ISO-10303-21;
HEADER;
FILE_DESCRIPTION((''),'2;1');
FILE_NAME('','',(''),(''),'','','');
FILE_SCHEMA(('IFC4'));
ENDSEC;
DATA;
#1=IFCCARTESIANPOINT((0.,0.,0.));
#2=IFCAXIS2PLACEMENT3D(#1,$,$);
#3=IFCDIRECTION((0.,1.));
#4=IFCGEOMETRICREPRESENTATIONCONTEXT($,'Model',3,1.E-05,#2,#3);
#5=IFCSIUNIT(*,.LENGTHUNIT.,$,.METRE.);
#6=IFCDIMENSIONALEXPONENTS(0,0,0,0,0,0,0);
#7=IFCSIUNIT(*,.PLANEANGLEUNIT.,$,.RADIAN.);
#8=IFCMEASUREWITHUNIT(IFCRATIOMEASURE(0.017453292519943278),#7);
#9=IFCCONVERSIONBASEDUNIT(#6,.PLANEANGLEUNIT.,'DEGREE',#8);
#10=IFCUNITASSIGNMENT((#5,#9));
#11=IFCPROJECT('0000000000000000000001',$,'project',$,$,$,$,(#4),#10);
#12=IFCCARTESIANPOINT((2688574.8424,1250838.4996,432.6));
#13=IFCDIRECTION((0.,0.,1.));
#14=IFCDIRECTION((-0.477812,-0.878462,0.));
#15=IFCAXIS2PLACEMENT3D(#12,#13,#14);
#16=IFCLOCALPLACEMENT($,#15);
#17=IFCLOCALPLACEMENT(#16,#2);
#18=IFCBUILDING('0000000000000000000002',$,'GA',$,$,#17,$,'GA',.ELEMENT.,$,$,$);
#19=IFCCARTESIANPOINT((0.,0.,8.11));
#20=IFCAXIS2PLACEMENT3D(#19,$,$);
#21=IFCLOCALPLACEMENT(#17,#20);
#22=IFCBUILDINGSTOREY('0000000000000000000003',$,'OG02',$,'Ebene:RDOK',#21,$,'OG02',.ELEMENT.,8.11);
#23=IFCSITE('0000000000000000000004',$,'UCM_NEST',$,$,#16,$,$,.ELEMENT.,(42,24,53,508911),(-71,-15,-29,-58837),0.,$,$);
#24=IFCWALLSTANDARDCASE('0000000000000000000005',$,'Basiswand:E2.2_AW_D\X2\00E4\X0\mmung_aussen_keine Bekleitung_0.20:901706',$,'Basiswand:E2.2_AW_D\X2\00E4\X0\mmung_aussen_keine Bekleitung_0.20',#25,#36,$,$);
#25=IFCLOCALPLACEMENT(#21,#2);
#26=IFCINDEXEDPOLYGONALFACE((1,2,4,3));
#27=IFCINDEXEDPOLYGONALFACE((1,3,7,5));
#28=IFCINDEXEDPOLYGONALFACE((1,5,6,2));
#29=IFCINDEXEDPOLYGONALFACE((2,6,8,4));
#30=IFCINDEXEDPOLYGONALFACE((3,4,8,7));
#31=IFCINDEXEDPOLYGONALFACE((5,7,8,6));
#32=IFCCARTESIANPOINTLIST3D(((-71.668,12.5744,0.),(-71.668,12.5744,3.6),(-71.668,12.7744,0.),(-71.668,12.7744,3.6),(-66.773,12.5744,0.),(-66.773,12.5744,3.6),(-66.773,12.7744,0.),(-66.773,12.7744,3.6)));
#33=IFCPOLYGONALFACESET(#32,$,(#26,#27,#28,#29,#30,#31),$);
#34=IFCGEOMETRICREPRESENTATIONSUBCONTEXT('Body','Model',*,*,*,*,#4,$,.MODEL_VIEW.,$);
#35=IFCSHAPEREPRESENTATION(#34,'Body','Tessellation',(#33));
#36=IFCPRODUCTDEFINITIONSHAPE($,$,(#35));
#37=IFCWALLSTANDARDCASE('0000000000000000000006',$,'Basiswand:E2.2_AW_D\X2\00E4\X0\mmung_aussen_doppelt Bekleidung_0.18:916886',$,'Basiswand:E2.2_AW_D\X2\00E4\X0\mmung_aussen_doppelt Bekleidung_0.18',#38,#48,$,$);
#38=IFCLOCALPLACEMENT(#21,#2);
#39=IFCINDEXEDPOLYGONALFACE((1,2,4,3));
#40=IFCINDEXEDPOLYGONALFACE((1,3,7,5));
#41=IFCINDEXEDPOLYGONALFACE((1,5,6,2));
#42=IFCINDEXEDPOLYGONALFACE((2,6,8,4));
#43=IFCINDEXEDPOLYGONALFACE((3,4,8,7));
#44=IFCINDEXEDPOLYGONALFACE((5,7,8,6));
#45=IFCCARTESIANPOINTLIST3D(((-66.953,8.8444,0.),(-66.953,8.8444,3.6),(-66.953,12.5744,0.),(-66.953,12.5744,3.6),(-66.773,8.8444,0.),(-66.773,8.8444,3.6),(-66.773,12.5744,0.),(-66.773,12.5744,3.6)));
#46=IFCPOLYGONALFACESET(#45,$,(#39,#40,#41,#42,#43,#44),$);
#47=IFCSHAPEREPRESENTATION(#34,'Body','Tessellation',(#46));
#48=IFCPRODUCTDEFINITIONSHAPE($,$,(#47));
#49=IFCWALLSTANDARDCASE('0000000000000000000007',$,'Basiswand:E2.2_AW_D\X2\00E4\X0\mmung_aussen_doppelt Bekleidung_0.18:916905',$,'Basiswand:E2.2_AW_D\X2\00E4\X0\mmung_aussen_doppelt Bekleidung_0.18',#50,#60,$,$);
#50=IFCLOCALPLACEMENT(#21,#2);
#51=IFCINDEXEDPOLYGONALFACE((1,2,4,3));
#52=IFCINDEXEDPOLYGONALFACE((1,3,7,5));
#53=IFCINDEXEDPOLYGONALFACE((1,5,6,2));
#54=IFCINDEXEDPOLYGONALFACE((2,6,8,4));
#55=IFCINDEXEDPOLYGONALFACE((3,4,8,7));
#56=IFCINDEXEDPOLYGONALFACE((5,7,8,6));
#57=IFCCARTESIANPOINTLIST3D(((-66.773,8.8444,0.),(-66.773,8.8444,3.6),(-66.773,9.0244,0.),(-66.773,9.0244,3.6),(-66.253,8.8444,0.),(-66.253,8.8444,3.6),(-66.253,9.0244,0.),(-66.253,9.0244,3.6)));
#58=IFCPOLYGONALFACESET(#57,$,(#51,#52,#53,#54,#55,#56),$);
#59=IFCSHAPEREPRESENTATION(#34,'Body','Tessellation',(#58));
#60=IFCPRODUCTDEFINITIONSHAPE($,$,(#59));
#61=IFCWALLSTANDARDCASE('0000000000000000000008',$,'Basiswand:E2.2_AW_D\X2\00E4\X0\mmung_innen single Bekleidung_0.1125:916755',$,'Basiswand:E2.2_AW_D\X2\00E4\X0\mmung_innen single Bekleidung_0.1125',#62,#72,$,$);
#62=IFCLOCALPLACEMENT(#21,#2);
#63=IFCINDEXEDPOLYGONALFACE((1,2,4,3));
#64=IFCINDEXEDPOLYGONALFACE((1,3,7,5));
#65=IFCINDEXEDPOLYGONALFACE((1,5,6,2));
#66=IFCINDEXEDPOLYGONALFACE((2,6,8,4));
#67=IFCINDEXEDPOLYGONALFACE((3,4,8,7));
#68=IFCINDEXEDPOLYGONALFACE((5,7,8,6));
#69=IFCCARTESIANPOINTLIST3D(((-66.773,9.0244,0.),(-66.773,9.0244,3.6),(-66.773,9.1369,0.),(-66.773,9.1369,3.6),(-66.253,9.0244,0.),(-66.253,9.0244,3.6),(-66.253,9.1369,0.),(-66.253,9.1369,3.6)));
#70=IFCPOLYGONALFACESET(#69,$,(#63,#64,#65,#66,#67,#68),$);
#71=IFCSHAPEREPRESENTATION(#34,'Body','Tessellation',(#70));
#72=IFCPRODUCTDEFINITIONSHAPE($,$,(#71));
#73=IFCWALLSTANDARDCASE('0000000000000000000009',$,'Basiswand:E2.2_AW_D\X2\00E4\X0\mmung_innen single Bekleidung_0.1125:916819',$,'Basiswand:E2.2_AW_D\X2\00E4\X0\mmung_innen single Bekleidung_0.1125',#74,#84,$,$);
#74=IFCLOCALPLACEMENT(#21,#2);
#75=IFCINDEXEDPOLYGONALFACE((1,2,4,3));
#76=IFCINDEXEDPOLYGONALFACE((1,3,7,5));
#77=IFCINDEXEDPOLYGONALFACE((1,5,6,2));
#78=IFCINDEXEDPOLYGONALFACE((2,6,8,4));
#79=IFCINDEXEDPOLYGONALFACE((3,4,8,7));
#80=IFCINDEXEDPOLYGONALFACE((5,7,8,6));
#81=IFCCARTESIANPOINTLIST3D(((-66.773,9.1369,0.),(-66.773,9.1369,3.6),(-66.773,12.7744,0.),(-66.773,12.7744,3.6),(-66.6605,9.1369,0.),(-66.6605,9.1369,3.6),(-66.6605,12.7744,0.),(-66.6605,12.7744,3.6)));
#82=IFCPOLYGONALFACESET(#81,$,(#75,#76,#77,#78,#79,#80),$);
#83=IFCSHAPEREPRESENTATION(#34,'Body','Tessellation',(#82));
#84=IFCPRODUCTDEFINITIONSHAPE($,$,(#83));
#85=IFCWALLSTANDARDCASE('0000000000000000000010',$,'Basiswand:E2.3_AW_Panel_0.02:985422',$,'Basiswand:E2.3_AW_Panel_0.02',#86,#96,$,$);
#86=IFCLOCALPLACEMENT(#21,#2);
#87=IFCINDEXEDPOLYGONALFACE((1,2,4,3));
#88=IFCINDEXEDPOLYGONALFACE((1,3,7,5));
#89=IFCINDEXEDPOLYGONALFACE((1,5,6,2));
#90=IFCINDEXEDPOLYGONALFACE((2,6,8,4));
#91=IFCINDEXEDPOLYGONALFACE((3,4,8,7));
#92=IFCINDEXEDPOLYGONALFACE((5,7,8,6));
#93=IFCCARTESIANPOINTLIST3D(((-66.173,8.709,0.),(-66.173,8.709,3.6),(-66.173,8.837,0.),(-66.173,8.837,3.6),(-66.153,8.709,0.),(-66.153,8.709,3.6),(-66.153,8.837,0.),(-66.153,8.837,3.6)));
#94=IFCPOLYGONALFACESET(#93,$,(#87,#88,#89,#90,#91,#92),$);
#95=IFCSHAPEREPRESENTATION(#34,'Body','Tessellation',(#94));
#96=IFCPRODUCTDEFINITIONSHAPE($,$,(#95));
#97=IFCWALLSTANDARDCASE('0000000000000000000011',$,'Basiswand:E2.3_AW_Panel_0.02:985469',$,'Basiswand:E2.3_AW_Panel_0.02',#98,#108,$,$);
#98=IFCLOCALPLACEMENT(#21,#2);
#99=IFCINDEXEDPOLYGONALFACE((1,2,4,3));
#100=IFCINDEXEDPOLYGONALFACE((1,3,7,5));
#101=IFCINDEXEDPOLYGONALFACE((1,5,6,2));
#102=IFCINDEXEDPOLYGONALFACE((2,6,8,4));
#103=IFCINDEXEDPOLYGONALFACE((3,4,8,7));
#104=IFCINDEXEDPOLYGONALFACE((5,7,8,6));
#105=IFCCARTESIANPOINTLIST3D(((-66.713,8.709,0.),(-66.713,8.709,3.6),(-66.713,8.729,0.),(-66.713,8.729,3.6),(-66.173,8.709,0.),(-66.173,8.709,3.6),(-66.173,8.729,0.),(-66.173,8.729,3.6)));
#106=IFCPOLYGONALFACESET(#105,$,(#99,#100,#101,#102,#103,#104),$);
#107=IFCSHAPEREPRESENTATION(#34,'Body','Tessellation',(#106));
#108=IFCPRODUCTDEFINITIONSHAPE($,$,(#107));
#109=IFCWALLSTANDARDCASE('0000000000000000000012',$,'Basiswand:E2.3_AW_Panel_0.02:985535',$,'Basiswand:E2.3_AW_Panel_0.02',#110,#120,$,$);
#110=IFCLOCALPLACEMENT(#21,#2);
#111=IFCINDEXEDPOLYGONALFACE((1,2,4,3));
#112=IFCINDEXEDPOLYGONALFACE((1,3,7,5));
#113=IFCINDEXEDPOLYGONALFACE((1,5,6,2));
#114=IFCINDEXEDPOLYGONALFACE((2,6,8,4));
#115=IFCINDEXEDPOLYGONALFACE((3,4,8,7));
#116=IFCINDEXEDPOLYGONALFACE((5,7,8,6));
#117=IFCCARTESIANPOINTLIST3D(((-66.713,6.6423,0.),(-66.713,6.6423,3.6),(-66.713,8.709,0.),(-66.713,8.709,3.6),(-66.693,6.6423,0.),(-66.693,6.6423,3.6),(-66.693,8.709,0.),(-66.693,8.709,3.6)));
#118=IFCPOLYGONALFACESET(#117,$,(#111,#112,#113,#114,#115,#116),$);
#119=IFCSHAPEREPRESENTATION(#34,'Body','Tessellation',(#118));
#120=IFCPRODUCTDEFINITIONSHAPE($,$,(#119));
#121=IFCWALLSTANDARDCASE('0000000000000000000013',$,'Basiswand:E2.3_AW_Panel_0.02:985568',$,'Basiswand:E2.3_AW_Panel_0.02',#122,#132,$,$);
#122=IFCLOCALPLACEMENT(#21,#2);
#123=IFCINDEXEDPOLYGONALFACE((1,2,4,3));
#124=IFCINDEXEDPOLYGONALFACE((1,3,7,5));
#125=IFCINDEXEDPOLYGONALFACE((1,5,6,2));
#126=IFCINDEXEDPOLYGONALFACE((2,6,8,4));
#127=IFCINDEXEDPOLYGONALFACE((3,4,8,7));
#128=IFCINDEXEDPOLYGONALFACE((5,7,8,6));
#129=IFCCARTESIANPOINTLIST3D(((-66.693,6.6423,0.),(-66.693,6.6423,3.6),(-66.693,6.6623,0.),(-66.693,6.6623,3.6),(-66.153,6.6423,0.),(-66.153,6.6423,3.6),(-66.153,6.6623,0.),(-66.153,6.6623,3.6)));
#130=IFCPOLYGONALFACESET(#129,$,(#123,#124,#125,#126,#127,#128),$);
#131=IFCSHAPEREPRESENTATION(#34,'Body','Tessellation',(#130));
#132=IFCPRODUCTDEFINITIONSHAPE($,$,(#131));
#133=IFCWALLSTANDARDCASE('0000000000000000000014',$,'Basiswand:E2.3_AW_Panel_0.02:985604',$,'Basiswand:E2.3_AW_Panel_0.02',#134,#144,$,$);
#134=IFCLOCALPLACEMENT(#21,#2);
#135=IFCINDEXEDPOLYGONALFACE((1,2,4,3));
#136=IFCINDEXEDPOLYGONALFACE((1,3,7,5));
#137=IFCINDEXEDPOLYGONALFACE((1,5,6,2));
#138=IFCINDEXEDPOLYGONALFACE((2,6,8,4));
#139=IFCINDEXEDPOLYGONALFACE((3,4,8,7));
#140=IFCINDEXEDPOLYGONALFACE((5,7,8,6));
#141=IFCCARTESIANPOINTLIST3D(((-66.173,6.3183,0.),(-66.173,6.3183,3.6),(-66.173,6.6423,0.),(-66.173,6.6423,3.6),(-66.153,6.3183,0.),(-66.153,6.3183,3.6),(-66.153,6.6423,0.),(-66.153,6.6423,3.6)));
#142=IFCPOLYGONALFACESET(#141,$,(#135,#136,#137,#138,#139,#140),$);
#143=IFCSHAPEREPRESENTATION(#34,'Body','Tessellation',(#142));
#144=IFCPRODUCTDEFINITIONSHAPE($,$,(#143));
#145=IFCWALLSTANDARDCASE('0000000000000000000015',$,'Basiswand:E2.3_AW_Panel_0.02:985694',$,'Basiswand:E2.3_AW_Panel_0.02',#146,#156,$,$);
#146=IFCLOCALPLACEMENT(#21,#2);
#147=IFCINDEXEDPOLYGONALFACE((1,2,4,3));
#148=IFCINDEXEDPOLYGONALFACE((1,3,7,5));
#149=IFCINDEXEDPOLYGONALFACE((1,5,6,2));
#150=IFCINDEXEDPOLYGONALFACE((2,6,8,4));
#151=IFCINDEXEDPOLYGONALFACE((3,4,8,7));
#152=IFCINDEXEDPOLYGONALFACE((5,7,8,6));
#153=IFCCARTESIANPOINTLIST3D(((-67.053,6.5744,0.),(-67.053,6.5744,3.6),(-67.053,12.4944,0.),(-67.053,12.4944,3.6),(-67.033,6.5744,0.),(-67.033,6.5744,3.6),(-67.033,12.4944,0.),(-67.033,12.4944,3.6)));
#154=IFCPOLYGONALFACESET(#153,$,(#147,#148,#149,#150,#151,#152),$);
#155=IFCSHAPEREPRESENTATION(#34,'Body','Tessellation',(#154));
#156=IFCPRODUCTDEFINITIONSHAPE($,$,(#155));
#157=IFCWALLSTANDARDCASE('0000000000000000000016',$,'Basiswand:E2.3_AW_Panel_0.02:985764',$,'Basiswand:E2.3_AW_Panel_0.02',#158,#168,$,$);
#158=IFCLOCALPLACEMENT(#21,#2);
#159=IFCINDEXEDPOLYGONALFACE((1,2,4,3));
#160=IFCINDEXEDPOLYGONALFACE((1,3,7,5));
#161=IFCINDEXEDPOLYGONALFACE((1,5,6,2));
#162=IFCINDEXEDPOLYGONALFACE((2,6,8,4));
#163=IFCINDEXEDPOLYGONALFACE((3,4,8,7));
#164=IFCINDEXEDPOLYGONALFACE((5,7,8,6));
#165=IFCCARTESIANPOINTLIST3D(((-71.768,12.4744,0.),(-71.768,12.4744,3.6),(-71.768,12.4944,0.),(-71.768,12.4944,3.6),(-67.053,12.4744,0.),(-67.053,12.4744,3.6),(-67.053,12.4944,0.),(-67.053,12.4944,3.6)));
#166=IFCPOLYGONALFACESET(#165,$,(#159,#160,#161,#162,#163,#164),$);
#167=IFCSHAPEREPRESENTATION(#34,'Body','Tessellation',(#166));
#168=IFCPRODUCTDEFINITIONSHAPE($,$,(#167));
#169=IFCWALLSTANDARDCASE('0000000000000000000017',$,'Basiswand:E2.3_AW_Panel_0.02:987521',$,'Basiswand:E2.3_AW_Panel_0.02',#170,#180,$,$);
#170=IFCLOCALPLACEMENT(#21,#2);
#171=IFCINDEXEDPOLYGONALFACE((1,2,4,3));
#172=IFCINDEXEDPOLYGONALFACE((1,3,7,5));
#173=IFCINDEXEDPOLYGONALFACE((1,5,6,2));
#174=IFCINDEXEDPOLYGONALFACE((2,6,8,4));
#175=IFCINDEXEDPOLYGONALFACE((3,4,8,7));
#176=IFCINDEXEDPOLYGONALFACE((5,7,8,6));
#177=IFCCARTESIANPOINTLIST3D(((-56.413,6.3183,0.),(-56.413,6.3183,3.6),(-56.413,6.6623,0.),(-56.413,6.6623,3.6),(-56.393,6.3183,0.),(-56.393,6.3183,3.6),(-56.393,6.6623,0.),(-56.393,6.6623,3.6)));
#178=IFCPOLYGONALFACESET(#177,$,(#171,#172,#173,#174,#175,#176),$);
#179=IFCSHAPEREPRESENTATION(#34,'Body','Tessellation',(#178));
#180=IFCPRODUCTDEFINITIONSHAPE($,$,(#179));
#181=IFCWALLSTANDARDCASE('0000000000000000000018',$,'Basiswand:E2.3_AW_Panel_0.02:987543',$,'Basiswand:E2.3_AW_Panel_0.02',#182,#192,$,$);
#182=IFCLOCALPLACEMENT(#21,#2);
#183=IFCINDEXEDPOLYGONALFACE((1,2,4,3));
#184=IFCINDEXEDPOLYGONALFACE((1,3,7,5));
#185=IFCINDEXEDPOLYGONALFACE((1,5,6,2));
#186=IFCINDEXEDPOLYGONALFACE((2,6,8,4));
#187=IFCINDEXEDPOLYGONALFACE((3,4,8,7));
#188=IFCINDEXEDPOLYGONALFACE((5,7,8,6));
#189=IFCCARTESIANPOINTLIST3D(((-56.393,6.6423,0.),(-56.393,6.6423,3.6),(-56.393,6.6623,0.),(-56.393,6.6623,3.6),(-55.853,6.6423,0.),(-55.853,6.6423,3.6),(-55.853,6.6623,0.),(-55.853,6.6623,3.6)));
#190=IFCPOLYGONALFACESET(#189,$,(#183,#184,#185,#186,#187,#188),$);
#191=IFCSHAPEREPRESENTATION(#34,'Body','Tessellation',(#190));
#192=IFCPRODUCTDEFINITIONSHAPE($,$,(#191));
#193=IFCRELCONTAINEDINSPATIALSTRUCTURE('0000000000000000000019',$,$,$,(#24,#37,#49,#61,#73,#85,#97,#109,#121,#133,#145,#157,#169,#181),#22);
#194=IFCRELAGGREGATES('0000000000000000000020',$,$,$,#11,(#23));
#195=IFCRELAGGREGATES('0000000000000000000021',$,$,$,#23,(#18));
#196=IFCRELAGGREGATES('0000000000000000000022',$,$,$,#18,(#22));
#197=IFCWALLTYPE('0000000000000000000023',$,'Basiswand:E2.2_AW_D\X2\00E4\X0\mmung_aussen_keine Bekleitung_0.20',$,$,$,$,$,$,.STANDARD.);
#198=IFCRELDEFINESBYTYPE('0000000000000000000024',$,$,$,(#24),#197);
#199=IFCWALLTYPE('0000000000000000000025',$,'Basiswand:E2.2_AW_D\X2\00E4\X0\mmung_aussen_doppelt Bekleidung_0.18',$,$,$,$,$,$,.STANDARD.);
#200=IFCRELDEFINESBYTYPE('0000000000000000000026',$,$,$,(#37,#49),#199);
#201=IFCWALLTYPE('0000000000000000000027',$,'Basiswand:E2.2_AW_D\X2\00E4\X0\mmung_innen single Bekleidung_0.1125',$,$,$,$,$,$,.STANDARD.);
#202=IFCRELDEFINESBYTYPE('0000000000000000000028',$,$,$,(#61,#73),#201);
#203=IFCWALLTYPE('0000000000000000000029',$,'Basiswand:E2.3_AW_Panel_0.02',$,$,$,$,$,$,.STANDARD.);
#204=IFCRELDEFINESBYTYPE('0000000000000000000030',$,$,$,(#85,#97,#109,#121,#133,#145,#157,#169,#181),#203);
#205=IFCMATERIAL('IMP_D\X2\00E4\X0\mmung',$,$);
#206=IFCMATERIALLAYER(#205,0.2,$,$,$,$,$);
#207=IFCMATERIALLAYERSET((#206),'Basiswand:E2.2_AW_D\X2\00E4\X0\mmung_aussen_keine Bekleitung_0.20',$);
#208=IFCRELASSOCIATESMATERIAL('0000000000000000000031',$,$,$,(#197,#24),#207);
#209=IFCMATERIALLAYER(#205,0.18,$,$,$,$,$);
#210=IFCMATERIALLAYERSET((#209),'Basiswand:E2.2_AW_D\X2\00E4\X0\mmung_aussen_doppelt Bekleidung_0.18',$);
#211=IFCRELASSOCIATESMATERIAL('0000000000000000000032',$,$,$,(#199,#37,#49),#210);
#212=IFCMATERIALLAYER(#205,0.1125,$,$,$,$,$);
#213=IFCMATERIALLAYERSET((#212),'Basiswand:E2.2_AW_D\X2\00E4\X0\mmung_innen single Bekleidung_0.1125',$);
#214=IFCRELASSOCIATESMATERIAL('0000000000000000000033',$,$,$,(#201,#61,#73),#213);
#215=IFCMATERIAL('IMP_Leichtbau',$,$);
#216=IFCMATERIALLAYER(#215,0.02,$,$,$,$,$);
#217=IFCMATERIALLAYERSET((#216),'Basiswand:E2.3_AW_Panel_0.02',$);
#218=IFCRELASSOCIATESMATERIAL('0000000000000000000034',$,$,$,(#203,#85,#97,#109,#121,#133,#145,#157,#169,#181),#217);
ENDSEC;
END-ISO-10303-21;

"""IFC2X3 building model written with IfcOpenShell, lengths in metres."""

from ifc_helpers import new_model, entity, si_unit, converted_unit, direction, frame, frame_2d, origin, place, context, subcontext, project, spatial, rectangle, extrude, material, layer, layer_set, layer_usage, type_object, element, save


model = new_model("IFC2X3")

# Units and contexts
model_context = context("Model", 3, precision=1e-05, world=origin(), true_north=direction((0.0, 1.0)))
body_context = subcontext(model_context, "Body", "Model", "MODEL_VIEW")
ifc_project = project(units=[si_unit("LENGTHUNIT", "METRE"), converted_unit("PLANEANGLEUNIT", "DEGREE", entity("IfcRatioMeasure", 0.017453292519943278), si_unit("PLANEANGLEUNIT", "RADIAN"), dimensions=[0, 0, 0, 0, 0, 0, 0])], contexts=[model_context])

# Site, building, storey
site_placement = place(None, frame((2688574.8424, 1250838.4996, 432.6), z_axis=(0.0, 0.0, 1.0), x_axis=(-0.477812, -0.878462, 0.0)))
site = spatial("IfcSite", under=ifc_project, at=site_placement, Name="UCM_NEST", CompositionType="ELEMENT", RefLatitude=(42, 24, 53, 508911), RefLongitude=(-71, -15, -29, -58837), RefElevation=0.0)
building_placement = place(site_placement, origin())
building = spatial("IfcBuilding", under=site, at=building_placement, Name="GA", LongName="GA", CompositionType="ELEMENT")
storey_placement = place(building_placement, frame((0.0, 0.0, 8.11)))
storey = spatial("IfcBuildingStorey", under=building, at=storey_placement, Name="OG02", ObjectType="Ebene:RDOK", LongName="OG02", CompositionType="ELEMENT", Elevation=8.11)

# Walls
ifc_material_1 = material(Name="IMP_Dämmung")
ifc_layer_1 = layer(ifc_material_1, 0.2)
ifc_layer_set_1 = layer_set([ifc_layer_1], Name="Basiswand:E2.2_AW_Dämmung_aussen_keine Bekleitung_0.20")
ifc_layer_usage_1 = layer_usage(ifc_layer_set_1, "AXIS2", "NEGATIVE", 0.1)
wall_type_1 = type_object("IfcWallType", Name="Basiswand:E2.2_AW_Dämmung_aussen_keine Bekleitung_0.20", PredefinedType="STANDARD", material=ifc_layer_set_1)
wall_1_placement = place(storey_placement, frame((-66.773, 12.6744, 0.0), z_axis=(0.0, 0.0, 1.0), x_axis=(-1.0, 0.0, 0.0)))
element("IfcWallStandardCase", 1, at=wall_1_placement, inside=storey, type_object=wall_type_1, material=ifc_layer_usage_1, Name="Basiswand:E2.2_AW_Dämmung_aussen_keine Bekleitung_0.20:901706", ObjectType="Basiswand:E2.2_AW_Dämmung_aussen_keine Bekleitung_0.20", context=body_context, shape_type="SweptSolid", body=[
    extrude(rectangle(XDim=4.895, YDim=0.2, at=frame_2d((2.4475, 0.0), x_axis=(-1.0, 0.0))), origin(), (0.0, 0.0, 1.0), 3.6),
])
ifc_layer_2 = layer(ifc_material_1, 0.18)
ifc_layer_set_2 = layer_set([ifc_layer_2], Name="Basiswand:E2.2_AW_Dämmung_aussen_doppelt Bekleidung_0.18")
ifc_layer_usage_2 = layer_usage(ifc_layer_set_2, "AXIS2", "NEGATIVE", 0.09)
wall_type_2 = type_object("IfcWallType", Name="Basiswand:E2.2_AW_Dämmung_aussen_doppelt Bekleidung_0.18", PredefinedType="STANDARD", material=ifc_layer_set_2)
wall_2_placement = place(storey_placement, frame((-66.863, 12.5744, 0.0), z_axis=(0.0, 0.0, 1.0), x_axis=(0.0, -1.0, 0.0)))
element("IfcWallStandardCase", 2, at=wall_2_placement, inside=storey, type_object=wall_type_2, material=ifc_layer_usage_2, Name="Basiswand:E2.2_AW_Dämmung_aussen_doppelt Bekleidung_0.18:916886", ObjectType="Basiswand:E2.2_AW_Dämmung_aussen_doppelt Bekleidung_0.18", context=body_context, shape_type="SweptSolid", body=[
    extrude(rectangle(XDim=3.73, YDim=0.18, at=frame_2d((1.865, 0.0), x_axis=(-1.0, 0.0))), origin(), (0.0, 0.0, 1.0), 3.6),
])
wall_3_placement = place(storey_placement, frame((-66.773, 8.9344, 0.0)))
element("IfcWallStandardCase", 3, at=wall_3_placement, inside=storey, type_object=wall_type_2, material=ifc_layer_usage_2, Name="Basiswand:E2.2_AW_Dämmung_aussen_doppelt Bekleidung_0.18:916905", ObjectType="Basiswand:E2.2_AW_Dämmung_aussen_doppelt Bekleidung_0.18", context=body_context, shape_type="SweptSolid", body=[
    extrude(rectangle(XDim=0.52, YDim=0.18, at=frame_2d((0.26, 0.0), x_axis=(-1.0, 0.0))), origin(), (0.0, 0.0, 1.0), 3.6),
])
ifc_layer_3 = layer(ifc_material_1, 0.1125)
ifc_layer_set_3 = layer_set([ifc_layer_3], Name="Basiswand:E2.2_AW_Dämmung_innen single Bekleidung_0.1125")
ifc_layer_usage_3 = layer_usage(ifc_layer_set_3, "AXIS2", "NEGATIVE", 0.0562)
wall_type_3 = type_object("IfcWallType", Name="Basiswand:E2.2_AW_Dämmung_innen single Bekleidung_0.1125", PredefinedType="STANDARD", material=ifc_layer_set_3)
wall_4_placement = place(storey_placement, frame((-66.253, 9.0807, 0.0), z_axis=(0.0, 0.0, 1.0), x_axis=(-1.0, 0.0, 0.0)))
element("IfcWallStandardCase", 4, at=wall_4_placement, inside=storey, type_object=wall_type_3, material=ifc_layer_usage_3, Name="Basiswand:E2.2_AW_Dämmung_innen single Bekleidung_0.1125:916755", ObjectType="Basiswand:E2.2_AW_Dämmung_innen single Bekleidung_0.1125", context=body_context, shape_type="SweptSolid", body=[
    extrude(rectangle(XDim=0.52, YDim=0.1125, at=frame_2d((0.26, 0.0), x_axis=(-1.0, 0.0))), origin(), (0.0, 0.0, 1.0), 3.6),
])
wall_5_placement = place(storey_placement, frame((-66.7168, 9.1369, 0.0), z_axis=(0.0, 0.0, 1.0), x_axis=(0.0, 1.0, 0.0)))
element("IfcWallStandardCase", 5, at=wall_5_placement, inside=storey, type_object=wall_type_3, material=ifc_layer_usage_3, Name="Basiswand:E2.2_AW_Dämmung_innen single Bekleidung_0.1125:916819", ObjectType="Basiswand:E2.2_AW_Dämmung_innen single Bekleidung_0.1125", context=body_context, shape_type="SweptSolid", body=[
    extrude(rectangle(XDim=3.6375, YDim=0.1125, at=frame_2d((1.8187, 0.0), x_axis=(-1.0, 0.0))), origin(), (0.0, 0.0, 1.0), 3.6),
])
ifc_material_2 = material(Name="IMP_Leichtbau")
ifc_layer_4 = layer(ifc_material_2, 0.02)
ifc_layer_set_4 = layer_set([ifc_layer_4], Name="Basiswand:E2.3_AW_Panel_0.02")
ifc_layer_usage_4 = layer_usage(ifc_layer_set_4, "AXIS2", "NEGATIVE", 0.01)
wall_type_4 = type_object("IfcWallType", Name="Basiswand:E2.3_AW_Panel_0.02", PredefinedType="STANDARD", material=ifc_layer_set_4)
wall_6_placement = place(storey_placement, frame((-66.163, 8.837, 0.0), z_axis=(0.0, 0.0, 1.0), x_axis=(0.0, -1.0, 0.0)))
element("IfcWallStandardCase", 6, at=wall_6_placement, inside=storey, type_object=wall_type_4, material=ifc_layer_usage_4, Name="Basiswand:E2.3_AW_Panel_0.02:985422", ObjectType="Basiswand:E2.3_AW_Panel_0.02", context=body_context, shape_type="SweptSolid", body=[
    extrude(rectangle(XDim=0.128, YDim=0.02, at=frame_2d((0.064, 0.0), x_axis=(-1.0, 0.0))), origin(), (0.0, 0.0, 1.0), 3.6),
])
wall_7_placement = place(storey_placement, frame((-66.173, 8.719, 0.0), z_axis=(0.0, 0.0, 1.0), x_axis=(-1.0, 0.0, 0.0)))
element("IfcWallStandardCase", 7, at=wall_7_placement, inside=storey, type_object=wall_type_4, material=ifc_layer_usage_4, Name="Basiswand:E2.3_AW_Panel_0.02:985469", ObjectType="Basiswand:E2.3_AW_Panel_0.02", context=body_context, shape_type="SweptSolid", body=[
    extrude(rectangle(XDim=0.54, YDim=0.02, at=frame_2d((0.27, 0.0), x_axis=(-1.0, 0.0))), origin(), (0.0, 0.0, 1.0), 3.6),
])
wall_8_placement = place(storey_placement, frame((-66.703, 8.709, 0.0), z_axis=(0.0, 0.0, 1.0), x_axis=(0.0, -1.0, 0.0)))
element("IfcWallStandardCase", 8, at=wall_8_placement, inside=storey, type_object=wall_type_4, material=ifc_layer_usage_4, Name="Basiswand:E2.3_AW_Panel_0.02:985535", ObjectType="Basiswand:E2.3_AW_Panel_0.02", context=body_context, shape_type="SweptSolid", body=[
    extrude(rectangle(XDim=2.0667, YDim=0.02, at=frame_2d((1.0333, 0.0), x_axis=(-1.0, 0.0))), origin(), (0.0, 0.0, 1.0), 3.6),
])
wall_9_placement = place(storey_placement, frame((-66.693, 6.6523, 0.0)))
element("IfcWallStandardCase", 9, at=wall_9_placement, inside=storey, type_object=wall_type_4, material=ifc_layer_usage_4, Name="Basiswand:E2.3_AW_Panel_0.02:985568", ObjectType="Basiswand:E2.3_AW_Panel_0.02", context=body_context, shape_type="SweptSolid", body=[
    extrude(rectangle(XDim=0.54, YDim=0.02, at=frame_2d((0.27, 0.0), x_axis=(-1.0, 0.0))), origin(), (0.0, 0.0, 1.0), 3.6),
])
wall_10_placement = place(storey_placement, frame((-66.163, 6.6423, 0.0), z_axis=(0.0, 0.0, 1.0), x_axis=(0.0, -1.0, 0.0)))
element("IfcWallStandardCase", 10, at=wall_10_placement, inside=storey, type_object=wall_type_4, material=ifc_layer_usage_4, Name="Basiswand:E2.3_AW_Panel_0.02:985604", ObjectType="Basiswand:E2.3_AW_Panel_0.02", context=body_context, shape_type="SweptSolid", body=[
    extrude(rectangle(XDim=0.324, YDim=0.02, at=frame_2d((0.162, 0.0), x_axis=(-1.0, 0.0))), origin(), (0.0, 0.0, 1.0), 3.6),
])
wall_11_placement = place(storey_placement, frame((-67.043, 6.5744, 0.0), z_axis=(0.0, 0.0, 1.0), x_axis=(0.0, 1.0, 0.0)))
element("IfcWallStandardCase", 11, at=wall_11_placement, inside=storey, type_object=wall_type_4, material=ifc_layer_usage_4, Name="Basiswand:E2.3_AW_Panel_0.02:985694", ObjectType="Basiswand:E2.3_AW_Panel_0.02", context=body_context, shape_type="SweptSolid", body=[
    extrude(rectangle(XDim=5.92, YDim=0.02, at=frame_2d((2.96, 0.0), x_axis=(-1.0, 0.0))), origin(), (0.0, 0.0, 1.0), 3.6),
])
wall_12_placement = place(storey_placement, frame((-67.053, 12.4844, 0.0), z_axis=(0.0, 0.0, 1.0), x_axis=(-1.0, 0.0, 0.0)))
element("IfcWallStandardCase", 12, at=wall_12_placement, inside=storey, type_object=wall_type_4, material=ifc_layer_usage_4, Name="Basiswand:E2.3_AW_Panel_0.02:985764", ObjectType="Basiswand:E2.3_AW_Panel_0.02", context=body_context, shape_type="SweptSolid", body=[
    extrude(rectangle(XDim=4.715, YDim=0.02, at=frame_2d((2.3575, 0.0), x_axis=(-1.0, 0.0))), origin(), (0.0, 0.0, 1.0), 3.6),
])
wall_13_placement = place(storey_placement, frame((-56.403, 6.3183, 0.0), z_axis=(0.0, 0.0, 1.0), x_axis=(0.0, 1.0, 0.0)))
element("IfcWallStandardCase", 13, at=wall_13_placement, inside=storey, type_object=wall_type_4, material=ifc_layer_usage_4, Name="Basiswand:E2.3_AW_Panel_0.02:987521", ObjectType="Basiswand:E2.3_AW_Panel_0.02", context=body_context, shape_type="SweptSolid", body=[
    extrude(rectangle(XDim=0.344, YDim=0.02, at=frame_2d((0.172, 0.0), x_axis=(-1.0, 0.0))), origin(), (0.0, 0.0, 1.0), 3.6),
])
wall_14_placement = place(storey_placement, frame((-56.393, 6.6523, 0.0)))
element("IfcWallStandardCase", 14, at=wall_14_placement, inside=storey, type_object=wall_type_4, material=ifc_layer_usage_4, Name="Basiswand:E2.3_AW_Panel_0.02:987543", ObjectType="Basiswand:E2.3_AW_Panel_0.02", context=body_context, shape_type="SweptSolid", body=[
    extrude(rectangle(XDim=0.54, YDim=0.02, at=frame_2d((0.27, 0.0), x_axis=(-1.0, 0.0))), origin(), (0.0, 0.0, 1.0), 3.6),
])

save(model, "model.ifc")
